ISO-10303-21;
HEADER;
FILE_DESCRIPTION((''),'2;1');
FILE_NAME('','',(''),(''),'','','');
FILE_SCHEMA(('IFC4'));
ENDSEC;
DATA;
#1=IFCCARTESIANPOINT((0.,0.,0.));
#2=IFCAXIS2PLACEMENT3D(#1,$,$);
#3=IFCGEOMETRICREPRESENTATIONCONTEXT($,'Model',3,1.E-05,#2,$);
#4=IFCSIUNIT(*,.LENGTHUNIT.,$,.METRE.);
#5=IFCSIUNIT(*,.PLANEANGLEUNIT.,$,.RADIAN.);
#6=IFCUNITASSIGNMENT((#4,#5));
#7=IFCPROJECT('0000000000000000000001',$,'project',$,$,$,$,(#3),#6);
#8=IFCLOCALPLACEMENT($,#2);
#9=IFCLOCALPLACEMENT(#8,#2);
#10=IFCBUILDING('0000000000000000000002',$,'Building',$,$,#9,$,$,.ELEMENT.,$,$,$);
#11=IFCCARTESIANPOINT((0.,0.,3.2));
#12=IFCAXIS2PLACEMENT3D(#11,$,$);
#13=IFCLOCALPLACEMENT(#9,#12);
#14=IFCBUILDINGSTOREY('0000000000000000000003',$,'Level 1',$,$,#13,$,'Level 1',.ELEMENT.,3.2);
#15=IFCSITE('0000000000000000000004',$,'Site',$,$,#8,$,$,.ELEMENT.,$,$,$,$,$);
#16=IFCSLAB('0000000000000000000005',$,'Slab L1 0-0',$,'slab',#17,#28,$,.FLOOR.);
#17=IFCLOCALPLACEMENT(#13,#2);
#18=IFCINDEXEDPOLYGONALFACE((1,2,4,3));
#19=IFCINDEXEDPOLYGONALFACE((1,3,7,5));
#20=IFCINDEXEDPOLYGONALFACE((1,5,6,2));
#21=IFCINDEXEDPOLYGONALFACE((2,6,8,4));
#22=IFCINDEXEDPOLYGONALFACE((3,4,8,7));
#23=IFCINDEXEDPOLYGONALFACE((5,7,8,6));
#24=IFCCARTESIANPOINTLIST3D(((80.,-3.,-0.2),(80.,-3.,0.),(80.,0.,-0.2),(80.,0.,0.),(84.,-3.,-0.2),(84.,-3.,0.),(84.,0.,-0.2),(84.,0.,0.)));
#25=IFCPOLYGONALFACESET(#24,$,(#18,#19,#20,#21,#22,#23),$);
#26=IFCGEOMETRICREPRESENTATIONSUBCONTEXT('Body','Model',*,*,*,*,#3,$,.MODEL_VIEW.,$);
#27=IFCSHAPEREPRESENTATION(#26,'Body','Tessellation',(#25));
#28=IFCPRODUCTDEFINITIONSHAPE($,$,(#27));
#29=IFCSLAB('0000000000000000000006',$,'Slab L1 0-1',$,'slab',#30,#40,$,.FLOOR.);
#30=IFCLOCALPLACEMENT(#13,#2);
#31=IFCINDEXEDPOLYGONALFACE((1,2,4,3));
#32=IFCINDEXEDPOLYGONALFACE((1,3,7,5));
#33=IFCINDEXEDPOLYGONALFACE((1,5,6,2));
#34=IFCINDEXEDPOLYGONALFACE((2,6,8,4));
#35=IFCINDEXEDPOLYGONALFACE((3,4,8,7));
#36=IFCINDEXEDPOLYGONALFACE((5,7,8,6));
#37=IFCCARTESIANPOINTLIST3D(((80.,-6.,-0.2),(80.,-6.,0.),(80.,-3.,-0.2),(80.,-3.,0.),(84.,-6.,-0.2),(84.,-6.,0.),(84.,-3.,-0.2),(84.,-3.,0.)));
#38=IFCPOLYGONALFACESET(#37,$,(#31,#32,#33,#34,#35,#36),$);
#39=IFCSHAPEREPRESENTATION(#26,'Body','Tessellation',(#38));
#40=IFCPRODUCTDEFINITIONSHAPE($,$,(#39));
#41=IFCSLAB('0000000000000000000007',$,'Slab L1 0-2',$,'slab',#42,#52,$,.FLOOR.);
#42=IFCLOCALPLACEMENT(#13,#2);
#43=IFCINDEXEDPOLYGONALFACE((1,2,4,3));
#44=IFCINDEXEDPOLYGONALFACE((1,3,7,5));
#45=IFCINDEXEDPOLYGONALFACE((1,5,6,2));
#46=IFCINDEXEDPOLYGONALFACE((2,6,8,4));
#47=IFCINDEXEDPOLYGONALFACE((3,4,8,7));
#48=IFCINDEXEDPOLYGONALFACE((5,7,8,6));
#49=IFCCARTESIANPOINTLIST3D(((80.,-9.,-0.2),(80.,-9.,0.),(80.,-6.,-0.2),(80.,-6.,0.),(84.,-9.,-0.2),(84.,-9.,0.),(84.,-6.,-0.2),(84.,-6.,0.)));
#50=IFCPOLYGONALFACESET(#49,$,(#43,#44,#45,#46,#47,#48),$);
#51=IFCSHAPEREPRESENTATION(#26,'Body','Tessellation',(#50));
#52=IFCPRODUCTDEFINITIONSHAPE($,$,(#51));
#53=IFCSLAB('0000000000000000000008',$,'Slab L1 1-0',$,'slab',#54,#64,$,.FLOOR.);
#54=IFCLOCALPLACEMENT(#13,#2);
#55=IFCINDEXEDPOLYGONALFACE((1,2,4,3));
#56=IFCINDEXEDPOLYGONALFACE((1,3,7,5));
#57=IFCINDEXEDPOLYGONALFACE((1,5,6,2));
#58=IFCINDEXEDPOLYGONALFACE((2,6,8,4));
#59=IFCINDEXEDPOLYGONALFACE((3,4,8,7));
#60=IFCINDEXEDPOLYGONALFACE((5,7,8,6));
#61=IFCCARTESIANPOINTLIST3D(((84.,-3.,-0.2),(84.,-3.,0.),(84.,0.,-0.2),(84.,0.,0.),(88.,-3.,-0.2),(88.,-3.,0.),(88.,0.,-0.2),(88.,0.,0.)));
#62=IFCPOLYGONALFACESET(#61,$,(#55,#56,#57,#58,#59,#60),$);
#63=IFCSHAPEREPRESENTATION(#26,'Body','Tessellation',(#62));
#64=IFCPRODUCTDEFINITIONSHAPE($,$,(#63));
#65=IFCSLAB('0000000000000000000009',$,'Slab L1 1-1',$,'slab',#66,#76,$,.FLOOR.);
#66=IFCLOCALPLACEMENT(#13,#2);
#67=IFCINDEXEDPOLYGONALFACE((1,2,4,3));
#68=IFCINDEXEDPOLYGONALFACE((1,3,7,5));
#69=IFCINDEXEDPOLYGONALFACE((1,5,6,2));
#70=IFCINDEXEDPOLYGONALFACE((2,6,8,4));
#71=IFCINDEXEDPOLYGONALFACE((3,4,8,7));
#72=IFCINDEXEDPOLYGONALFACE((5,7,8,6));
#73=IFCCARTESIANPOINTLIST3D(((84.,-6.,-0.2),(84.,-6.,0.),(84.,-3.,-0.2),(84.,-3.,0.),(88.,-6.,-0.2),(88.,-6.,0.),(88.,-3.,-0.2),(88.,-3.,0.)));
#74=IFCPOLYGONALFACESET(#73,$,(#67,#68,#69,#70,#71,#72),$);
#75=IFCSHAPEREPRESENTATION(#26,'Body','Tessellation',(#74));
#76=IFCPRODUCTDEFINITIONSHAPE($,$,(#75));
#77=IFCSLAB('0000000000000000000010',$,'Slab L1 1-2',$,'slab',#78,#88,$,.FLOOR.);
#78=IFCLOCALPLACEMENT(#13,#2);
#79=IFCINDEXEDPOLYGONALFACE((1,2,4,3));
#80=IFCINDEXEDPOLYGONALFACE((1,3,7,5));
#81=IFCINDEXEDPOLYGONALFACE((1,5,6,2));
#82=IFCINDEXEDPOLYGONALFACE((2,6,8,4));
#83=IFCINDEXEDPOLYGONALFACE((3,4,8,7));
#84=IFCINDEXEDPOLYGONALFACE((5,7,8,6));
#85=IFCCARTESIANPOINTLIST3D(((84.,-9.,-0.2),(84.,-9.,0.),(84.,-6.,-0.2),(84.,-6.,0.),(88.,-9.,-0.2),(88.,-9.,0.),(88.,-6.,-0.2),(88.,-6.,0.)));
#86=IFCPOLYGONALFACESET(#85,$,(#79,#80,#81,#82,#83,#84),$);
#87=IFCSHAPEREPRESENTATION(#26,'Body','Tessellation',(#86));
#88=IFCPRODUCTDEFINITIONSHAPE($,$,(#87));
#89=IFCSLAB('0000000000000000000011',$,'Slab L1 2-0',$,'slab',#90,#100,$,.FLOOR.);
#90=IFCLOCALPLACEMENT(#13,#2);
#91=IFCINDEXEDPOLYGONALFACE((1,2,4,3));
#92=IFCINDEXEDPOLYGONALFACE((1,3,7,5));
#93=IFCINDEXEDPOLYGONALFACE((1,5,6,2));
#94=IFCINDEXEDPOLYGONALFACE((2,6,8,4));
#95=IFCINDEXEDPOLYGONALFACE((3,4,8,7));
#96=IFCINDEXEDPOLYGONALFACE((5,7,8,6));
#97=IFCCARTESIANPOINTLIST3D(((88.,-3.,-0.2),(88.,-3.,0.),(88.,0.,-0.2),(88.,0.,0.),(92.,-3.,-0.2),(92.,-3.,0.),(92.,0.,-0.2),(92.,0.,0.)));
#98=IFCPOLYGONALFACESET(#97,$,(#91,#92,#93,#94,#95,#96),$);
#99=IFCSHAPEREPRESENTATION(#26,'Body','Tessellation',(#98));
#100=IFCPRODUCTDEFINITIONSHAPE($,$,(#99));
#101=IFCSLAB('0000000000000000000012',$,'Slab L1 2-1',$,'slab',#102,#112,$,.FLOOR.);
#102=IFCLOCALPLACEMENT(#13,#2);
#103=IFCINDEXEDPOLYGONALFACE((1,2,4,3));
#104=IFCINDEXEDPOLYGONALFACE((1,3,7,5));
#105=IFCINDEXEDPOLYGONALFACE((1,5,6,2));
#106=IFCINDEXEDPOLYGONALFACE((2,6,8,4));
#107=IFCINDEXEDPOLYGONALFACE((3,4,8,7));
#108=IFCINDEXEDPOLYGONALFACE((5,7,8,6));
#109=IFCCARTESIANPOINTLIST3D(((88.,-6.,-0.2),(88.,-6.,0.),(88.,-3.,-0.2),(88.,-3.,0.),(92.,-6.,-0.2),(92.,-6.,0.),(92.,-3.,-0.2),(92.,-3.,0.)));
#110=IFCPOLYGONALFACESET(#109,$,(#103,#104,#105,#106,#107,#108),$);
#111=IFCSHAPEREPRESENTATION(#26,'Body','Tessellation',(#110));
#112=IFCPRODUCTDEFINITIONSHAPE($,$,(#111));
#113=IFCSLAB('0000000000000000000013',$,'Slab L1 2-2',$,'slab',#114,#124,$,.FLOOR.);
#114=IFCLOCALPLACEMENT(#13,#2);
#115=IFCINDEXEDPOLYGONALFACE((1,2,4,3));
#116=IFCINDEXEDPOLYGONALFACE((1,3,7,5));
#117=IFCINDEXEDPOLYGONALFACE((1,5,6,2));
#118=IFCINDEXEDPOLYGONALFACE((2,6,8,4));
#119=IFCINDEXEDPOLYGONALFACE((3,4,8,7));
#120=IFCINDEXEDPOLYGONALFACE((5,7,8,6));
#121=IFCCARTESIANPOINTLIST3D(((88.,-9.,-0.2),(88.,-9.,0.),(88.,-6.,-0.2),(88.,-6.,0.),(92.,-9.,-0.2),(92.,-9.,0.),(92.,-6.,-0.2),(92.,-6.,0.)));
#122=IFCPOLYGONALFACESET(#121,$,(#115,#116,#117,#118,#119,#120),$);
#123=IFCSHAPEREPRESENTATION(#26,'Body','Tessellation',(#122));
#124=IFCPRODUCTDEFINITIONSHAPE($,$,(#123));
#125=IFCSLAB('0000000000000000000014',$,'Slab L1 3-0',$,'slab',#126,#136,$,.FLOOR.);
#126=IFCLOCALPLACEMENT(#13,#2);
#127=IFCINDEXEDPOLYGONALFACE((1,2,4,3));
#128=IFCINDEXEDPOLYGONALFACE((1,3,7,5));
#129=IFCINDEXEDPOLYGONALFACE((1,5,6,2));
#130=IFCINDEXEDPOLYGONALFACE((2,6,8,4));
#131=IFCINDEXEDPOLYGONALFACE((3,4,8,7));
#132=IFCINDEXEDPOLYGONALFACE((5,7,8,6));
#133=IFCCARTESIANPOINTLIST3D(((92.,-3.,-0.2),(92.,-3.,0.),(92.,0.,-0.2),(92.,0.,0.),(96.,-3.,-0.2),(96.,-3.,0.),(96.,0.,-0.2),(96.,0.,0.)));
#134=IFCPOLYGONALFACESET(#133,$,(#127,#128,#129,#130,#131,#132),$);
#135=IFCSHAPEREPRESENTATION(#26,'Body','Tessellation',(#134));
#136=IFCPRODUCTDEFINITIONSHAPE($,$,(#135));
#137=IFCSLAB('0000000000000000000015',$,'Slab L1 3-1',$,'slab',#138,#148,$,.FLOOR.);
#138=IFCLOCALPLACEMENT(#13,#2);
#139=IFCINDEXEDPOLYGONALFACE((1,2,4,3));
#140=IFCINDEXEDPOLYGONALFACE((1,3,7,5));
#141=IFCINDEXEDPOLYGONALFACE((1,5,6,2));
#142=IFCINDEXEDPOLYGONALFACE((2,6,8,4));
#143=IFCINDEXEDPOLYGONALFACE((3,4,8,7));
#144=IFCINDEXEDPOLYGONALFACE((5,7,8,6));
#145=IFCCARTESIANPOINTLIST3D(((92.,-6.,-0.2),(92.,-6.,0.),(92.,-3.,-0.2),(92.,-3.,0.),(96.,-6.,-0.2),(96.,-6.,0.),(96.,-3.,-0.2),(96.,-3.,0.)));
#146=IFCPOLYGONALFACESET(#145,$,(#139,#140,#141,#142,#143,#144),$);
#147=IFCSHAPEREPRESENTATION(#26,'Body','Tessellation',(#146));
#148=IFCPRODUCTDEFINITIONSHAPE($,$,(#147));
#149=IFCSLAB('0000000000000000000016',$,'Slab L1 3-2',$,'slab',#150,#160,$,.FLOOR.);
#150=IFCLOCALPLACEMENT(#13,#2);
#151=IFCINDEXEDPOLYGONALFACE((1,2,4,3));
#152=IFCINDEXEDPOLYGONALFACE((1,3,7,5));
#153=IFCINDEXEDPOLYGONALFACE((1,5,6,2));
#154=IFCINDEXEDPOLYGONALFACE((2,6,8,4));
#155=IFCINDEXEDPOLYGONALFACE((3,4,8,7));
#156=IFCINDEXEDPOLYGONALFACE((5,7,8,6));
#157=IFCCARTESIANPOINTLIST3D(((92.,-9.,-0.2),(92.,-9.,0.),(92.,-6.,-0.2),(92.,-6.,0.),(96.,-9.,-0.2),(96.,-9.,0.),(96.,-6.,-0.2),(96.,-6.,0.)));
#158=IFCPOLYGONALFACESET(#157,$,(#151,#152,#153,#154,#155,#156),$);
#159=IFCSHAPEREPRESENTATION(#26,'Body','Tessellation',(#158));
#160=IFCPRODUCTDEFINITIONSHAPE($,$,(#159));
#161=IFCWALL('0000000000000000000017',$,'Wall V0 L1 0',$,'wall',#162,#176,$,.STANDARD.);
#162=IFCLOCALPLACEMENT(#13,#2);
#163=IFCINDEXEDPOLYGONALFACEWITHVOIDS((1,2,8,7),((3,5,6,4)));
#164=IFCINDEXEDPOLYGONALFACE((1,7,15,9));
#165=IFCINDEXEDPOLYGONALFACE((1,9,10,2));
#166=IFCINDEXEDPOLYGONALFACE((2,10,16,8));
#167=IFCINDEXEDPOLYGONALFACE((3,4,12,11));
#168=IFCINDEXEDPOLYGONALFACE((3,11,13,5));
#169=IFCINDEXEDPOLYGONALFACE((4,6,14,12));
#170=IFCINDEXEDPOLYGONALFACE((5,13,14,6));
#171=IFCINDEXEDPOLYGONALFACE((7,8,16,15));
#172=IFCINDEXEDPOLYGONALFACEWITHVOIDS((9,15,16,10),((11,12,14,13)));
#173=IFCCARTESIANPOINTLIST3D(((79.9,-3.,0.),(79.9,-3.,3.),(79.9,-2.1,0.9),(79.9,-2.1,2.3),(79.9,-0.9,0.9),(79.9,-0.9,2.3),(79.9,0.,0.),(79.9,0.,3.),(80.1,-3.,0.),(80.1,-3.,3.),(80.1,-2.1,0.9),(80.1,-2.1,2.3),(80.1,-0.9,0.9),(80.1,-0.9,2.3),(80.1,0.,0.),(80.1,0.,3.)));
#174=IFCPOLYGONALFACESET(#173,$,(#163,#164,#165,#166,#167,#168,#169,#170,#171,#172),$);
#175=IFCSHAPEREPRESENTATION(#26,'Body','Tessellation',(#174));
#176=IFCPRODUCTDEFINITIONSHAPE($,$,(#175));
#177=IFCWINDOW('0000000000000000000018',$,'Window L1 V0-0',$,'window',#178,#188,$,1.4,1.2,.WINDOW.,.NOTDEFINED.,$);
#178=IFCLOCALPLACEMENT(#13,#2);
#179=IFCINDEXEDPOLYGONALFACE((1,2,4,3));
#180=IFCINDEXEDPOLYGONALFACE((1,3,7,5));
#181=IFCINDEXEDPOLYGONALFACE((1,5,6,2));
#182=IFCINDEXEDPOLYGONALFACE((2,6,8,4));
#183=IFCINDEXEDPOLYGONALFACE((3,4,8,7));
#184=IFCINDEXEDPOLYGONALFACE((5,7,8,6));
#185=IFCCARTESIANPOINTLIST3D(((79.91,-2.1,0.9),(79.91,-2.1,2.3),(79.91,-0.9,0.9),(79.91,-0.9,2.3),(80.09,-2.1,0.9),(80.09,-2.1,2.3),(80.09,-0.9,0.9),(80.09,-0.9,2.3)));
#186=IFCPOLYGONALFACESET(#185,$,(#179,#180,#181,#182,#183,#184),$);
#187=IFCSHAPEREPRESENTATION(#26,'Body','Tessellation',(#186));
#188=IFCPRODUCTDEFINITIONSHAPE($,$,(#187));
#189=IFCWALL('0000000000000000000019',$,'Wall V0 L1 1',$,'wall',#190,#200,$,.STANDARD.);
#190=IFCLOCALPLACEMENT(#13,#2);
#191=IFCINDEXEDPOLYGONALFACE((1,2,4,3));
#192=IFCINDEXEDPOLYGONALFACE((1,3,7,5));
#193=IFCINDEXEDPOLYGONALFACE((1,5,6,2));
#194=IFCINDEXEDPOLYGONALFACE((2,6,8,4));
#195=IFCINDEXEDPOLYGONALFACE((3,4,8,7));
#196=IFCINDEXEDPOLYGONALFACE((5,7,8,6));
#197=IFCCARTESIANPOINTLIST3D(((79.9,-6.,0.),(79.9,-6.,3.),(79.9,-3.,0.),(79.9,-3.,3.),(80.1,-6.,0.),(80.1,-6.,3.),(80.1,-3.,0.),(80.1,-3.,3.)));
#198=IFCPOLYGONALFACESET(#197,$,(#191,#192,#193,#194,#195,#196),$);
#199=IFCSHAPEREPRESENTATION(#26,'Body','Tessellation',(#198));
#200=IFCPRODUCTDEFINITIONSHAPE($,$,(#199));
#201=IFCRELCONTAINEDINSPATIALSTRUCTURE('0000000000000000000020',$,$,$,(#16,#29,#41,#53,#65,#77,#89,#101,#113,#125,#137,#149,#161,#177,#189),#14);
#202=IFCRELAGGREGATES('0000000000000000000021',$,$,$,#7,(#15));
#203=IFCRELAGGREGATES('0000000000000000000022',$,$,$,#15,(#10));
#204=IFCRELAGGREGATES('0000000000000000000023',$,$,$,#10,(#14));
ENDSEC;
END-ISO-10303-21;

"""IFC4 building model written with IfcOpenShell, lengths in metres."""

from ifc_helpers import new_model, si_unit, frame, frame_2d, origin, origin_2d, place, context, subcontext, project, spatial, polyline, rectangle, outline, extrude, element, fill, save


model = new_model("IFC4")

# Units and contexts
model_context = context("Model", 3, precision=1e-05, world=origin())
body_context = subcontext(model_context, "Body", "Model", "MODEL_VIEW")
ifc_project = project(units=[si_unit("LENGTHUNIT", "METRE"), si_unit("PLANEANGLEUNIT", "RADIAN")], contexts=[model_context])

# Site, building, storey
site_placement = place(None, origin())
site = spatial("IfcSite", under=ifc_project, at=site_placement, Name="Site", CompositionType="ELEMENT")
building_placement = place(site_placement, origin())
building = spatial("IfcBuilding", under=site, at=building_placement, Name="Building", CompositionType="ELEMENT")
storey_placement = place(building_placement, frame((0.0, 0.0, 3.2)))
storey = spatial("IfcBuildingStorey", under=building, at=storey_placement, Name="Level 1", LongName="Level 1", CompositionType="ELEMENT", Elevation=3.2)

# Slabs
slab_1_placement = place(storey_placement, frame((0.0, 0.0, -0.2)))
element("IfcSlab", 1, at=slab_1_placement, inside=storey, Name="Slab L1 0-0", ObjectType="slab", PredefinedType="FLOOR", context=body_context, shape_type="SweptSolid", body=[
    extrude(outline(polyline([(80.0, -3.0), (84.0, -3.0), (84.0, 0.0), (80.0, 0.0), (80.0, -3.0)])), origin(), (0.0, 0.0, 1.0), 0.2),
])
slab_2_placement = place(storey_placement, frame((0.0, 0.0, -0.2)))
element("IfcSlab", 2, at=slab_2_placement, inside=storey, Name="Slab L1 0-1", ObjectType="slab", PredefinedType="FLOOR", context=body_context, shape_type="SweptSolid", body=[
    extrude(outline(polyline([(80.0, -6.0), (84.0, -6.0), (84.0, -3.0), (80.0, -3.0), (80.0, -6.0)])), origin(), (0.0, 0.0, 1.0), 0.2),
])
slab_3_placement = place(storey_placement, frame((0.0, 0.0, -0.2)))
element("IfcSlab", 3, at=slab_3_placement, inside=storey, Name="Slab L1 0-2", ObjectType="slab", PredefinedType="FLOOR", context=body_context, shape_type="SweptSolid", body=[
    extrude(outline(polyline([(80.0, -9.0), (84.0, -9.0), (84.0, -6.0), (80.0, -6.0), (80.0, -9.0)])), origin(), (0.0, 0.0, 1.0), 0.2),
])
slab_4_placement = place(storey_placement, frame((0.0, 0.0, -0.2)))
element("IfcSlab", 4, at=slab_4_placement, inside=storey, Name="Slab L1 1-0", ObjectType="slab", PredefinedType="FLOOR", context=body_context, shape_type="SweptSolid", body=[
    extrude(outline(polyline([(84.0, -3.0), (88.0, -3.0), (88.0, 0.0), (84.0, 0.0), (84.0, -3.0)])), origin(), (0.0, 0.0, 1.0), 0.2),
])
slab_5_placement = place(storey_placement, frame((0.0, 0.0, -0.2)))
element("IfcSlab", 5, at=slab_5_placement, inside=storey, Name="Slab L1 1-1", ObjectType="slab", PredefinedType="FLOOR", context=body_context, shape_type="SweptSolid", body=[
    extrude(outline(polyline([(84.0, -6.0), (88.0, -6.0), (88.0, -3.0), (84.0, -3.0), (84.0, -6.0)])), origin(), (0.0, 0.0, 1.0), 0.2),
])
slab_6_placement = place(storey_placement, frame((0.0, 0.0, -0.2)))
element("IfcSlab", 6, at=slab_6_placement, inside=storey, Name="Slab L1 1-2", ObjectType="slab", PredefinedType="FLOOR", context=body_context, shape_type="SweptSolid", body=[
    extrude(outline(polyline([(84.0, -9.0), (88.0, -9.0), (88.0, -6.0), (84.0, -6.0), (84.0, -9.0)])), origin(), (0.0, 0.0, 1.0), 0.2),
])
slab_7_placement = place(storey_placement, frame((0.0, 0.0, -0.2)))
element("IfcSlab", 7, at=slab_7_placement, inside=storey, Name="Slab L1 2-0", ObjectType="slab", PredefinedType="FLOOR", context=body_context, shape_type="SweptSolid", body=[
    extrude(outline(polyline([(88.0, -3.0), (92.0, -3.0), (92.0, 0.0), (88.0, 0.0), (88.0, -3.0)])), origin(), (0.0, 0.0, 1.0), 0.2),
])
slab_8_placement = place(storey_placement, frame((0.0, 0.0, -0.2)))
element("IfcSlab", 8, at=slab_8_placement, inside=storey, Name="Slab L1 2-1", ObjectType="slab", PredefinedType="FLOOR", context=body_context, shape_type="SweptSolid", body=[
    extrude(outline(polyline([(88.0, -6.0), (92.0, -6.0), (92.0, -3.0), (88.0, -3.0), (88.0, -6.0)])), origin(), (0.0, 0.0, 1.0), 0.2),
])
slab_9_placement = place(storey_placement, frame((0.0, 0.0, -0.2)))
element("IfcSlab", 9, at=slab_9_placement, inside=storey, Name="Slab L1 2-2", ObjectType="slab", PredefinedType="FLOOR", context=body_context, shape_type="SweptSolid", body=[
    extrude(outline(polyline([(88.0, -9.0), (92.0, -9.0), (92.0, -6.0), (88.0, -6.0), (88.0, -9.0)])), origin(), (0.0, 0.0, 1.0), 0.2),
])
slab_10_placement = place(storey_placement, frame((0.0, 0.0, -0.2)))
element("IfcSlab", 10, at=slab_10_placement, inside=storey, Name="Slab L1 3-0", ObjectType="slab", PredefinedType="FLOOR", context=body_context, shape_type="SweptSolid", body=[
    extrude(outline(polyline([(92.0, -3.0), (96.0, -3.0), (96.0, 0.0), (92.0, 0.0), (92.0, -3.0)])), origin(), (0.0, 0.0, 1.0), 0.2),
])
slab_11_placement = place(storey_placement, frame((0.0, 0.0, -0.2)))
element("IfcSlab", 11, at=slab_11_placement, inside=storey, Name="Slab L1 3-1", ObjectType="slab", PredefinedType="FLOOR", context=body_context, shape_type="SweptSolid", body=[
    extrude(outline(polyline([(92.0, -6.0), (96.0, -6.0), (96.0, -3.0), (92.0, -3.0), (92.0, -6.0)])), origin(), (0.0, 0.0, 1.0), 0.2),
])
slab_12_placement = place(storey_placement, frame((0.0, 0.0, -0.2)))
element("IfcSlab", 12, at=slab_12_placement, inside=storey, Name="Slab L1 3-2", ObjectType="slab", PredefinedType="FLOOR", context=body_context, shape_type="SweptSolid", body=[
    extrude(outline(polyline([(92.0, -9.0), (96.0, -9.0), (96.0, -6.0), (92.0, -6.0), (92.0, -9.0)])), origin(), (0.0, 0.0, 1.0), 0.2),
])

# Wall, opening, window
wall_1_placement = place(storey_placement, frame((80.0, 0.0, 0.0), z_axis=(0.0, 0.0, 1.0), x_axis=(0.0, -1.0, 0.0)))
wall_1 = element("IfcWall", 13, at=wall_1_placement, inside=storey, Name="Wall V0 L1 0", ObjectType="wall", PredefinedType="STANDARD", context=body_context, shape_type="SweptSolid", body=[
    extrude(rectangle(XDim=3.0, YDim=0.2, at=frame_2d((1.5, 0.0))), origin(), (0.0, 0.0, 1.0), 3.0),
])
opening_1_placement = place(storey_placement, frame((80.0, -1.5, 0.9), z_axis=(0.0, 0.0, 1.0), x_axis=(0.0, -1.0, 0.0)))
opening_1 = element("IfcOpeningElement", 14, at=opening_1_placement, cuts=wall_1, ObjectType="Opening", PredefinedType="OPENING", context=body_context, shape_type="SweptSolid", body=[
    extrude(rectangle(XDim=1.2, YDim=0.22, at=origin_2d()), origin(), (0.0, 0.0, 1.0), 1.4),
])
window_1_placement = place(storey_placement, frame((80.0, -1.5, 0.9), z_axis=(0.0, 0.0, 1.0), x_axis=(0.0, -1.0, 0.0)))
window_1 = element("IfcWindow", 15, at=window_1_placement, inside=storey, Name="Window L1 V0-0", ObjectType="window", OverallHeight=1.4, OverallWidth=1.2, PartitioningType="NOTDEFINED", PredefinedType="WINDOW", context=body_context, shape_type="SweptSolid", body=[
    extrude(rectangle(XDim=1.2, YDim=0.18, at=origin_2d()), origin(), (0.0, 0.0, 1.0), 1.4),
])
fill(opening_1, window_1)

# Wall
wall_2_placement = place(storey_placement, frame((80.0, -3.0, 0.0), z_axis=(0.0, 0.0, 1.0), x_axis=(0.0, -1.0, 0.0)))
element("IfcWall", 16, at=wall_2_placement, inside=storey, Name="Wall V0 L1 1", ObjectType="wall", PredefinedType="STANDARD", context=body_context, shape_type="SweptSolid", body=[
    extrude(rectangle(XDim=3.0, YDim=0.2, at=frame_2d((1.5, 0.0))), origin(), (0.0, 0.0, 1.0), 3.0),
])

save(model, "model.ifc")
